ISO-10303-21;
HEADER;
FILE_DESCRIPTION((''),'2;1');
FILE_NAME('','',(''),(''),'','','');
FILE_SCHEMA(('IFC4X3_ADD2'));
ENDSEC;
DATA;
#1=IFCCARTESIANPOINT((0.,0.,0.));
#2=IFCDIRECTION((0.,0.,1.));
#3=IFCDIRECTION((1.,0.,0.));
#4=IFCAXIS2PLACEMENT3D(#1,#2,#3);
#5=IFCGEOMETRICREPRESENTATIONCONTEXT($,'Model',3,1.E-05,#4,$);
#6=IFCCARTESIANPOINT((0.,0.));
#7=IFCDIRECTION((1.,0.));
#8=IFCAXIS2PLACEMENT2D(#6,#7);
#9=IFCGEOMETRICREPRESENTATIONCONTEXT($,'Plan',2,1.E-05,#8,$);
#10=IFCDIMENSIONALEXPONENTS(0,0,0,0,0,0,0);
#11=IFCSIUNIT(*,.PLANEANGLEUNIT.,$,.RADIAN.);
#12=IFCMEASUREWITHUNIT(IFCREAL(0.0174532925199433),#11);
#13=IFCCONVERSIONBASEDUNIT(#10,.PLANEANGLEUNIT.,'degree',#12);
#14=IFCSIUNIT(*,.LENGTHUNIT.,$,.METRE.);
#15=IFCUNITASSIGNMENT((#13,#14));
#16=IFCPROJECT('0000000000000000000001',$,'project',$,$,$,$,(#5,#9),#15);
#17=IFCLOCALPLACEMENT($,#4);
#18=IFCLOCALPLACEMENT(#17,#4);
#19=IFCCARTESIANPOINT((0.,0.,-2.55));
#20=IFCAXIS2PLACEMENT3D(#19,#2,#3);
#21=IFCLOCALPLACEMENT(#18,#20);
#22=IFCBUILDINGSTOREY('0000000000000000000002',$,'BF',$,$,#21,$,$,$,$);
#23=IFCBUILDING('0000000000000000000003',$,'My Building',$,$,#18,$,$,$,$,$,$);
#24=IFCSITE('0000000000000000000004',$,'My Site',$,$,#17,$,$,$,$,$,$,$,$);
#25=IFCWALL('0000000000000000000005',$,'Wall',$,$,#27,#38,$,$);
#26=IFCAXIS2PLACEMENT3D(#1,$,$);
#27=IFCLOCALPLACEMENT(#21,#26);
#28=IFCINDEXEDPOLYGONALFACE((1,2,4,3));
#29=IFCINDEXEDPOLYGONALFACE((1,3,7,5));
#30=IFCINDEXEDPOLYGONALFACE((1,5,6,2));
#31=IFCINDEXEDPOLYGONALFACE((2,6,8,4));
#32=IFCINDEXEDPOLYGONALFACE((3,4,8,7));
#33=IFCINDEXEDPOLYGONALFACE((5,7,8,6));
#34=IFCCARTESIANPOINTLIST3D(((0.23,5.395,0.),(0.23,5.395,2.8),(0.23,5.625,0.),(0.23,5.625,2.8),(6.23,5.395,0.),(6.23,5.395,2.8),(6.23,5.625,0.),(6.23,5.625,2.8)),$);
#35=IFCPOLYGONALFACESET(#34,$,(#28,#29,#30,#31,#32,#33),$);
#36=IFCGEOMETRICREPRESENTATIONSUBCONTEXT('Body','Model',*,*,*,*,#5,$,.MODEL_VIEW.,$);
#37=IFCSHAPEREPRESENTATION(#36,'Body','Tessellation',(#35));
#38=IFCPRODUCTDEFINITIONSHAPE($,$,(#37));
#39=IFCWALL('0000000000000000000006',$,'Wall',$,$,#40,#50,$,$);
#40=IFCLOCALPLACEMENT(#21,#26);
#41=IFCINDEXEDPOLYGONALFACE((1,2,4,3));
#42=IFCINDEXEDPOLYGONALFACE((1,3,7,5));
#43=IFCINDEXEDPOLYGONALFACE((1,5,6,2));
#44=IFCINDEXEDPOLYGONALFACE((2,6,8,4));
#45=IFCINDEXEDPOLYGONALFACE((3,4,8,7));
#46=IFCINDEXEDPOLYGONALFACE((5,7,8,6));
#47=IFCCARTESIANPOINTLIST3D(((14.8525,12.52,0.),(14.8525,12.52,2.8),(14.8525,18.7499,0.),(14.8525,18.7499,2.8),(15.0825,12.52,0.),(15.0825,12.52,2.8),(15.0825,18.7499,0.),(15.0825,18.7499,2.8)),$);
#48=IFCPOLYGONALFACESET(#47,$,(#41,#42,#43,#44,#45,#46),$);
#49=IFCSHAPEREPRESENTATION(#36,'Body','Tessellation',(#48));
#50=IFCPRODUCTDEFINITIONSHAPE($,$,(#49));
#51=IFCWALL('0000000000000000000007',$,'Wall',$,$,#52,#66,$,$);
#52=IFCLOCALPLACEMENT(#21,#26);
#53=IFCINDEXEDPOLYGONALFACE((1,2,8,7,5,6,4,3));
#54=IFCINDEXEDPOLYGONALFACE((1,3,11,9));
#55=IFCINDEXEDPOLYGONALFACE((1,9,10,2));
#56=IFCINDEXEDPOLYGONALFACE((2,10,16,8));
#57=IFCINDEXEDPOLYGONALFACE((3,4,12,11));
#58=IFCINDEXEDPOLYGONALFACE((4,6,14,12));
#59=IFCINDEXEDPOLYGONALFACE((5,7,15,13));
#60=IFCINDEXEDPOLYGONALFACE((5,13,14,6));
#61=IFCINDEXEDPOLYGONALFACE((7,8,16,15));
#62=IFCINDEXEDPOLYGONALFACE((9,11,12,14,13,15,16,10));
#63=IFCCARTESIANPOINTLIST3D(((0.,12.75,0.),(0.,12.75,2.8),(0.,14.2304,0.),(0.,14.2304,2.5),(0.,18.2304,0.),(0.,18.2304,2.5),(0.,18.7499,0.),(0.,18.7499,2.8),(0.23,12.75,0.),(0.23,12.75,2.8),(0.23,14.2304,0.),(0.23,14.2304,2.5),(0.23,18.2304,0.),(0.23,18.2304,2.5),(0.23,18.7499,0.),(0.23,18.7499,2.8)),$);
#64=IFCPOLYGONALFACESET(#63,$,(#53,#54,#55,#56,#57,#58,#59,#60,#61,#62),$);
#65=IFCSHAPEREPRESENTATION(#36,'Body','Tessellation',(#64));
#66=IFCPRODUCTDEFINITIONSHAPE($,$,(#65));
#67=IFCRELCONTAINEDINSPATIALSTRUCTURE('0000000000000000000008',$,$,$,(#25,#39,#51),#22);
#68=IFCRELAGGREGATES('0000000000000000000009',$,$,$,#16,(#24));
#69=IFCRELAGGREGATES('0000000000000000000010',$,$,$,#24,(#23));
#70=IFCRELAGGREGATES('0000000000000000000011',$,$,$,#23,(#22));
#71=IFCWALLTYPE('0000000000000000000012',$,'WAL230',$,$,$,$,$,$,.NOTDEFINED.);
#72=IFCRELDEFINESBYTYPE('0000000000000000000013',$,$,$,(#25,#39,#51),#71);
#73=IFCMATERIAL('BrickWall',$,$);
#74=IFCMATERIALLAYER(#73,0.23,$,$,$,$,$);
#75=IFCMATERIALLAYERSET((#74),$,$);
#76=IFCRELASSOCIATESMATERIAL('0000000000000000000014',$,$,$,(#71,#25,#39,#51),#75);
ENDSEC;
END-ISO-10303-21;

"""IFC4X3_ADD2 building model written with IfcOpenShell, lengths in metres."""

from ifc_helpers import new_model, entity, si_unit, converted_unit, frame, origin_with_axes, origin_2d_with_axis, place, context, subcontext, project, spatial, line, indexed_curve, outline, extrude, source, transform, mapped, material, layer, layer_set, layer_usage, type_object, element, save


model = new_model("IFC4X3_ADD2")

# Units and contexts
model_context = context("Model", 3, precision=1e-05, world=origin_with_axes())
plan_context = context("Plan", 2, precision=1e-05, world=origin_2d_with_axis())
body_context_1 = subcontext(model_context, "Body", "Model", "MODEL_VIEW")
ifc_project = project(units=[converted_unit("PLANEANGLEUNIT", "degree", entity("IfcReal", 0.0174532925199433), si_unit("PLANEANGLEUNIT", "RADIAN"), dimensions=[0, 0, 0, 0, 0, 0, 0]), si_unit("LENGTHUNIT", "METRE")], contexts=[model_context, plan_context])

# Site, building, storey
site_placement = place(None, origin_with_axes())
site = spatial("IfcSite", under=ifc_project, at=site_placement, Name="My Site")
building_placement = place(site_placement, origin_with_axes())
building = spatial("IfcBuilding", under=site, at=building_placement, Name="My Building")
storey_placement = place(building_placement, frame((0.0, 0.0, -2.55), z_axis=(0.0, 0.0, 1.0), x_axis=(1.0, 0.0, 0.0)))
storey = spatial("IfcBuildingStorey", under=building, at=storey_placement, Name="BF")

# Shared definitions
ifc_material_1 = material(Name="BrickWall")

# Shared definitions
ifc_layer_1 = layer(ifc_material_1, 0.23)
ifc_layer_set_1 = layer_set([ifc_layer_1])
wall_type = type_object("IfcWallType", Name="WAL230", PredefinedType="NOTDEFINED", material=ifc_layer_set_1)

# Shared definitions
shared_shape_1 = source(origin_with_axes(), body_context_1, "Body", "SweptSolid", [
    extrude(outline(indexed_curve([(0.0, 0.0), (4.0, 0.0), (4.0, 2.5), (0.0, 2.5)], segments=[line(1, 2, 3, 4, 1)])), frame((0.0, -0.6, 0.0), z_axis=(0.0, -1.0, 0.0), x_axis=(1.0, 0.0, 0.0)), (0.0, 0.0, -1.0), 1.2),
])

# Walls
ifc_layer_usage_1 = layer_usage(ifc_layer_set_1, "AXIS2", "POSITIVE", 0.0)
wall_1_placement = place(storey_placement, frame((0.23, 5.395, 0.0), z_axis=(0.0, 0.0, 1.0), x_axis=(1.0, 0.0, 0.0)))
element("IfcWall", 1, at=wall_1_placement, inside=storey, type_object=wall_type, material=ifc_layer_usage_1, Name="Wall", context=body_context_1, shape_type="SweptSolid", body=[
    extrude(outline(indexed_curve([(0.0, 0.0), (0.0, 0.23), (6.0, 0.23), (6.0, 0.0), (0.0, 0.0)], self_intersect=False)), origin_with_axes(), (0.0, 0.0, 1.0), 2.8),
])
ifc_layer_usage_2 = layer_usage(ifc_layer_set_1, "AXIS2", "POSITIVE", 0.0)
wall_2_placement = place(storey_placement, frame((15.0825, 12.52, 0.0), z_axis=(0.0, 0.0, 1.0), x_axis=(0.0, 1.0, 0.0)))
element("IfcWall", 2, at=wall_2_placement, inside=storey, type_object=wall_type, material=ifc_layer_usage_2, Name="Wall", context=body_context_1, shape_type="SweptSolid", body=[
    extrude(outline(indexed_curve([(0.0, 0.0), (0.0, 0.23), (6.2299, 0.23), (6.2299, 0.0), (0.0, 0.0)], self_intersect=False)), origin_with_axes(), (0.0, 0.0, 1.0), 2.8),
])

# Wall, opening
ifc_layer_usage_3 = layer_usage(ifc_layer_set_1, "AXIS2", "POSITIVE", 0.0)
wall_3_placement = place(storey_placement, frame((0.23, 12.75, 0.0), z_axis=(0.0, 0.0, 1.0), x_axis=(0.0, 1.0, 0.0)))
wall_3 = element("IfcWall", 3, at=wall_3_placement, inside=storey, type_object=wall_type, material=ifc_layer_usage_3, Name="Wall", context=body_context_1, shape_type="SweptSolid", body=[
    extrude(outline(indexed_curve([(0.0, 0.0), (0.0, 0.23), (5.9999, 0.23), (5.9999, 0.0), (0.0, 0.0)], self_intersect=False)), origin_with_axes(), (0.0, 0.0, 1.0), 2.8),
])
opening_1_placement = place(wall_3_placement, frame((1.4804, 0.0, 0.0), z_axis=(0.0, 0.0, 1.0), x_axis=(1.0, 0.0, 0.0)))
element("IfcOpeningElement", 4, at=opening_1_placement, cuts=wall_3, PredefinedType="OPENING", context=body_context_1, shape_type="MappedRepresentation", body=[
    mapped(shared_shape_1, transform((0.0, 0.0, 0.0), x_axis=(1.0, 0.0, 0.0), y_axis=(0.0, 1.0, 0.0), z_axis=(0.0, 0.0, 1.0), scale=1.0)),
])

save(model, "model.ifc")
